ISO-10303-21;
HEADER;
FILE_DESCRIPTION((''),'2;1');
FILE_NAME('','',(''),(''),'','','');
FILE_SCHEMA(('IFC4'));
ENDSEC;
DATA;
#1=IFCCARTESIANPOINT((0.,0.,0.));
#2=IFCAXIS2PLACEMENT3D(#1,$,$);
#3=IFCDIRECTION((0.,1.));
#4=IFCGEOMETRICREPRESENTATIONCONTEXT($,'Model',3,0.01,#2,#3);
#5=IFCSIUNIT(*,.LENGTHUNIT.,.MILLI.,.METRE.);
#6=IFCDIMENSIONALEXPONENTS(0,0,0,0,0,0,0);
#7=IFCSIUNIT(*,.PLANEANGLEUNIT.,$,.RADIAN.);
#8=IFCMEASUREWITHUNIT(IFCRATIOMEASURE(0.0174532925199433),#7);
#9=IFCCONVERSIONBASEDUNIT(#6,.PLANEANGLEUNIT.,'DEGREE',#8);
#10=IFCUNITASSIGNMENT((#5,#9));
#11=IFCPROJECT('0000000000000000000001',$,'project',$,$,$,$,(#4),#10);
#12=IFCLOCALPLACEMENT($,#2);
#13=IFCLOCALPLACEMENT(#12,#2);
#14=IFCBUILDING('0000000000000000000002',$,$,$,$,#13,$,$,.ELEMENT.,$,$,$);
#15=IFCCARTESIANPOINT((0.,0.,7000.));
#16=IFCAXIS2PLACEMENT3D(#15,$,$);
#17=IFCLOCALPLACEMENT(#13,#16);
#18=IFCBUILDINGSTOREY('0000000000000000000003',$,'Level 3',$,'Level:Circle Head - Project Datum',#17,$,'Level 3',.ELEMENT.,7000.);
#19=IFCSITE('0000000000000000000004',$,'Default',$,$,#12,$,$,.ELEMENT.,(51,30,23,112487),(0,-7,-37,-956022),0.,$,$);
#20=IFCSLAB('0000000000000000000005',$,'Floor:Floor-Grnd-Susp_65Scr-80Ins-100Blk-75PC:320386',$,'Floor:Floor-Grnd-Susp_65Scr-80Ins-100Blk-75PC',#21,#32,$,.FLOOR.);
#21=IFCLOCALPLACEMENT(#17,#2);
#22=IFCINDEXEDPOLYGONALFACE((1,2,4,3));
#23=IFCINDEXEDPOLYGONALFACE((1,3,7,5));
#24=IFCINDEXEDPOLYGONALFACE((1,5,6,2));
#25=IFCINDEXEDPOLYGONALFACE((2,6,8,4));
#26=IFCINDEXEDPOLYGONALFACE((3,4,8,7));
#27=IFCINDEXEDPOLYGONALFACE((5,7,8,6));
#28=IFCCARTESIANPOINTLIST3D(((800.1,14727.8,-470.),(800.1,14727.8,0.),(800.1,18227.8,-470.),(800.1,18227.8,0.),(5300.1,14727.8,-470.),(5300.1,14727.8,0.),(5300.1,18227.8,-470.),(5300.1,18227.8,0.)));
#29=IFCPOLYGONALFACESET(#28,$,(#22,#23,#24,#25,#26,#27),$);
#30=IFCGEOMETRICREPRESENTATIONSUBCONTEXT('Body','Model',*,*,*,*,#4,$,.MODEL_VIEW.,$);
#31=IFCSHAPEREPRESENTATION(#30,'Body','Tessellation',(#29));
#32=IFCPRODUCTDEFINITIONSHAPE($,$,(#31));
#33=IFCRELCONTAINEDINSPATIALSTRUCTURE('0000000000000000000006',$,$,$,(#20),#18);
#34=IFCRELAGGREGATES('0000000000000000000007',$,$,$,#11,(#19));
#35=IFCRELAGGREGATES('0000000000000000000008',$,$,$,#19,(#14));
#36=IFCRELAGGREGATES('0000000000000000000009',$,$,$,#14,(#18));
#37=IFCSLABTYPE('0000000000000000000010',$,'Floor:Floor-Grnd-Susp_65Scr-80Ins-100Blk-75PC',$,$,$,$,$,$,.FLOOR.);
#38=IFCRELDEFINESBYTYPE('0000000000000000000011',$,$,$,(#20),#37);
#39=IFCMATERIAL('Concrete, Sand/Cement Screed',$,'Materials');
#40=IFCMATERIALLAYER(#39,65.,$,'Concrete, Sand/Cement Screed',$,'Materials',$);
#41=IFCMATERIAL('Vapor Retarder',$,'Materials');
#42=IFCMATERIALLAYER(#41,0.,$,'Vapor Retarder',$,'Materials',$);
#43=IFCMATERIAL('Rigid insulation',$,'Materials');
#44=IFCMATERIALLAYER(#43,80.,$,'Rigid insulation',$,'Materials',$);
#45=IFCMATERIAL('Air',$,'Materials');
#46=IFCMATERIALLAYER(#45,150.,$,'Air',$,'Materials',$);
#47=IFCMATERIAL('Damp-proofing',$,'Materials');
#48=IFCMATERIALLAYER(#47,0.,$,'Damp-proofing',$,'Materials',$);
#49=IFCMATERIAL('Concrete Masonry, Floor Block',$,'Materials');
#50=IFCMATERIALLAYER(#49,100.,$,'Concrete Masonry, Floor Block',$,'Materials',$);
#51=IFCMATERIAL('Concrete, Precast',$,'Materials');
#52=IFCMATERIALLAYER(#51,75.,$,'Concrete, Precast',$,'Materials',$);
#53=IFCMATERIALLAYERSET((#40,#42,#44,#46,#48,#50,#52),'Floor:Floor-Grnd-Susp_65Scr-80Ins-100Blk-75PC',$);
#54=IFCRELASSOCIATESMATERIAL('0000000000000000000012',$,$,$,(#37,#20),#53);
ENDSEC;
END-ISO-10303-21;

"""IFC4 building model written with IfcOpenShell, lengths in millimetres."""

from ifc_helpers import new_model, entity, si_unit, converted_unit, direction, frame, origin, origin_2d_with_axis, place, context, subcontext, project, spatial, rectangle, extrude, material, layer, layer_set, layer_usage, type_object, element, save


model = new_model("IFC4")

# Units and contexts
model_context = context("Model", 3, precision=0.01, world=origin(), true_north=direction((0.0, 1.0)))
body_context = subcontext(model_context, "Body", "Model", "MODEL_VIEW")
ifc_project = project(units=[si_unit("LENGTHUNIT", "METRE", prefix="MILLI"), converted_unit("PLANEANGLEUNIT", "DEGREE", entity("IfcRatioMeasure", 0.0174532925199433), si_unit("PLANEANGLEUNIT", "RADIAN"), dimensions=[0, 0, 0, 0, 0, 0, 0])], contexts=[model_context])

# Site, building, storey
site_placement = place(None, origin())
site = spatial("IfcSite", under=ifc_project, at=site_placement, Name="Default", CompositionType="ELEMENT", RefLatitude=(51, 30, 23, 112487), RefLongitude=(0, -7, -37, -956022), RefElevation=0.0)
building_placement = place(site_placement, origin())
building = spatial("IfcBuilding", under=site, at=building_placement, CompositionType="ELEMENT")
storey_placement = place(building_placement, frame((0.0, 0.0, 7000.0)))
storey = spatial("IfcBuildingStorey", under=building, at=storey_placement, Name="Level 3", ObjectType="Level:Circle Head - Project Datum", LongName="Level 3", CompositionType="ELEMENT", Elevation=7000.0)

# Slab
ifc_material_1 = material(Name="Concrete, Sand/Cement Screed", Category="Materials")
ifc_layer_1 = layer(ifc_material_1, 65.0, Name="Concrete, Sand/Cement Screed", Category="Materials")
ifc_material_2 = material(Name="Vapor Retarder", Category="Materials")
ifc_layer_2 = layer(ifc_material_2, 0.0, Name="Vapor Retarder", Category="Materials")
ifc_material_3 = material(Name="Rigid insulation", Category="Materials")
ifc_layer_3 = layer(ifc_material_3, 80.0, Name="Rigid insulation", Category="Materials")
ifc_material_4 = material(Name="Air", Category="Materials")
ifc_layer_4 = layer(ifc_material_4, 150.0, Name="Air", Category="Materials")
ifc_material_5 = material(Name="Damp-proofing", Category="Materials")
ifc_layer_5 = layer(ifc_material_5, 0.0, Name="Damp-proofing", Category="Materials")
ifc_material_6 = material(Name="Concrete Masonry, Floor Block", Category="Materials")
ifc_layer_6 = layer(ifc_material_6, 100.0, Name="Concrete Masonry, Floor Block", Category="Materials")
ifc_material_7 = material(Name="Concrete, Precast", Category="Materials")
ifc_layer_7 = layer(ifc_material_7, 75.0, Name="Concrete, Precast", Category="Materials")
ifc_layer_set = layer_set([ifc_layer_1, ifc_layer_2, ifc_layer_3, ifc_layer_4, ifc_layer_5, ifc_layer_6, ifc_layer_7], Name="Floor:Floor-Grnd-Susp_65Scr-80Ins-100Blk-75PC")
ifc_layer_usage = layer_usage(ifc_layer_set, "AXIS3", "POSITIVE", 0.0)
slab_type = type_object("IfcSlabType", Name="Floor:Floor-Grnd-Susp_65Scr-80Ins-100Blk-75PC", PredefinedType="FLOOR", material=ifc_layer_set)
slab_placement = place(storey_placement, origin())
element("IfcSlab", 1, at=slab_placement, inside=storey, type_object=slab_type, material=ifc_layer_usage, Name="Floor:Floor-Grnd-Susp_65Scr-80Ins-100Blk-75PC:320386", ObjectType="Floor:Floor-Grnd-Susp_65Scr-80Ins-100Blk-75PC", PredefinedType="FLOOR", context=body_context, shape_type="SweptSolid", body=[
    extrude(rectangle(XDim=3500.0, YDim=4500.0, at=origin_2d_with_axis()), frame((3050.1, 16477.8, 0.0), z_axis=(0.0, 0.0, -1.0), x_axis=(0.0, 1.0, 0.0)), (0.0, 0.0, 1.0), 470.0),
])

save(model, "model.ifc")
